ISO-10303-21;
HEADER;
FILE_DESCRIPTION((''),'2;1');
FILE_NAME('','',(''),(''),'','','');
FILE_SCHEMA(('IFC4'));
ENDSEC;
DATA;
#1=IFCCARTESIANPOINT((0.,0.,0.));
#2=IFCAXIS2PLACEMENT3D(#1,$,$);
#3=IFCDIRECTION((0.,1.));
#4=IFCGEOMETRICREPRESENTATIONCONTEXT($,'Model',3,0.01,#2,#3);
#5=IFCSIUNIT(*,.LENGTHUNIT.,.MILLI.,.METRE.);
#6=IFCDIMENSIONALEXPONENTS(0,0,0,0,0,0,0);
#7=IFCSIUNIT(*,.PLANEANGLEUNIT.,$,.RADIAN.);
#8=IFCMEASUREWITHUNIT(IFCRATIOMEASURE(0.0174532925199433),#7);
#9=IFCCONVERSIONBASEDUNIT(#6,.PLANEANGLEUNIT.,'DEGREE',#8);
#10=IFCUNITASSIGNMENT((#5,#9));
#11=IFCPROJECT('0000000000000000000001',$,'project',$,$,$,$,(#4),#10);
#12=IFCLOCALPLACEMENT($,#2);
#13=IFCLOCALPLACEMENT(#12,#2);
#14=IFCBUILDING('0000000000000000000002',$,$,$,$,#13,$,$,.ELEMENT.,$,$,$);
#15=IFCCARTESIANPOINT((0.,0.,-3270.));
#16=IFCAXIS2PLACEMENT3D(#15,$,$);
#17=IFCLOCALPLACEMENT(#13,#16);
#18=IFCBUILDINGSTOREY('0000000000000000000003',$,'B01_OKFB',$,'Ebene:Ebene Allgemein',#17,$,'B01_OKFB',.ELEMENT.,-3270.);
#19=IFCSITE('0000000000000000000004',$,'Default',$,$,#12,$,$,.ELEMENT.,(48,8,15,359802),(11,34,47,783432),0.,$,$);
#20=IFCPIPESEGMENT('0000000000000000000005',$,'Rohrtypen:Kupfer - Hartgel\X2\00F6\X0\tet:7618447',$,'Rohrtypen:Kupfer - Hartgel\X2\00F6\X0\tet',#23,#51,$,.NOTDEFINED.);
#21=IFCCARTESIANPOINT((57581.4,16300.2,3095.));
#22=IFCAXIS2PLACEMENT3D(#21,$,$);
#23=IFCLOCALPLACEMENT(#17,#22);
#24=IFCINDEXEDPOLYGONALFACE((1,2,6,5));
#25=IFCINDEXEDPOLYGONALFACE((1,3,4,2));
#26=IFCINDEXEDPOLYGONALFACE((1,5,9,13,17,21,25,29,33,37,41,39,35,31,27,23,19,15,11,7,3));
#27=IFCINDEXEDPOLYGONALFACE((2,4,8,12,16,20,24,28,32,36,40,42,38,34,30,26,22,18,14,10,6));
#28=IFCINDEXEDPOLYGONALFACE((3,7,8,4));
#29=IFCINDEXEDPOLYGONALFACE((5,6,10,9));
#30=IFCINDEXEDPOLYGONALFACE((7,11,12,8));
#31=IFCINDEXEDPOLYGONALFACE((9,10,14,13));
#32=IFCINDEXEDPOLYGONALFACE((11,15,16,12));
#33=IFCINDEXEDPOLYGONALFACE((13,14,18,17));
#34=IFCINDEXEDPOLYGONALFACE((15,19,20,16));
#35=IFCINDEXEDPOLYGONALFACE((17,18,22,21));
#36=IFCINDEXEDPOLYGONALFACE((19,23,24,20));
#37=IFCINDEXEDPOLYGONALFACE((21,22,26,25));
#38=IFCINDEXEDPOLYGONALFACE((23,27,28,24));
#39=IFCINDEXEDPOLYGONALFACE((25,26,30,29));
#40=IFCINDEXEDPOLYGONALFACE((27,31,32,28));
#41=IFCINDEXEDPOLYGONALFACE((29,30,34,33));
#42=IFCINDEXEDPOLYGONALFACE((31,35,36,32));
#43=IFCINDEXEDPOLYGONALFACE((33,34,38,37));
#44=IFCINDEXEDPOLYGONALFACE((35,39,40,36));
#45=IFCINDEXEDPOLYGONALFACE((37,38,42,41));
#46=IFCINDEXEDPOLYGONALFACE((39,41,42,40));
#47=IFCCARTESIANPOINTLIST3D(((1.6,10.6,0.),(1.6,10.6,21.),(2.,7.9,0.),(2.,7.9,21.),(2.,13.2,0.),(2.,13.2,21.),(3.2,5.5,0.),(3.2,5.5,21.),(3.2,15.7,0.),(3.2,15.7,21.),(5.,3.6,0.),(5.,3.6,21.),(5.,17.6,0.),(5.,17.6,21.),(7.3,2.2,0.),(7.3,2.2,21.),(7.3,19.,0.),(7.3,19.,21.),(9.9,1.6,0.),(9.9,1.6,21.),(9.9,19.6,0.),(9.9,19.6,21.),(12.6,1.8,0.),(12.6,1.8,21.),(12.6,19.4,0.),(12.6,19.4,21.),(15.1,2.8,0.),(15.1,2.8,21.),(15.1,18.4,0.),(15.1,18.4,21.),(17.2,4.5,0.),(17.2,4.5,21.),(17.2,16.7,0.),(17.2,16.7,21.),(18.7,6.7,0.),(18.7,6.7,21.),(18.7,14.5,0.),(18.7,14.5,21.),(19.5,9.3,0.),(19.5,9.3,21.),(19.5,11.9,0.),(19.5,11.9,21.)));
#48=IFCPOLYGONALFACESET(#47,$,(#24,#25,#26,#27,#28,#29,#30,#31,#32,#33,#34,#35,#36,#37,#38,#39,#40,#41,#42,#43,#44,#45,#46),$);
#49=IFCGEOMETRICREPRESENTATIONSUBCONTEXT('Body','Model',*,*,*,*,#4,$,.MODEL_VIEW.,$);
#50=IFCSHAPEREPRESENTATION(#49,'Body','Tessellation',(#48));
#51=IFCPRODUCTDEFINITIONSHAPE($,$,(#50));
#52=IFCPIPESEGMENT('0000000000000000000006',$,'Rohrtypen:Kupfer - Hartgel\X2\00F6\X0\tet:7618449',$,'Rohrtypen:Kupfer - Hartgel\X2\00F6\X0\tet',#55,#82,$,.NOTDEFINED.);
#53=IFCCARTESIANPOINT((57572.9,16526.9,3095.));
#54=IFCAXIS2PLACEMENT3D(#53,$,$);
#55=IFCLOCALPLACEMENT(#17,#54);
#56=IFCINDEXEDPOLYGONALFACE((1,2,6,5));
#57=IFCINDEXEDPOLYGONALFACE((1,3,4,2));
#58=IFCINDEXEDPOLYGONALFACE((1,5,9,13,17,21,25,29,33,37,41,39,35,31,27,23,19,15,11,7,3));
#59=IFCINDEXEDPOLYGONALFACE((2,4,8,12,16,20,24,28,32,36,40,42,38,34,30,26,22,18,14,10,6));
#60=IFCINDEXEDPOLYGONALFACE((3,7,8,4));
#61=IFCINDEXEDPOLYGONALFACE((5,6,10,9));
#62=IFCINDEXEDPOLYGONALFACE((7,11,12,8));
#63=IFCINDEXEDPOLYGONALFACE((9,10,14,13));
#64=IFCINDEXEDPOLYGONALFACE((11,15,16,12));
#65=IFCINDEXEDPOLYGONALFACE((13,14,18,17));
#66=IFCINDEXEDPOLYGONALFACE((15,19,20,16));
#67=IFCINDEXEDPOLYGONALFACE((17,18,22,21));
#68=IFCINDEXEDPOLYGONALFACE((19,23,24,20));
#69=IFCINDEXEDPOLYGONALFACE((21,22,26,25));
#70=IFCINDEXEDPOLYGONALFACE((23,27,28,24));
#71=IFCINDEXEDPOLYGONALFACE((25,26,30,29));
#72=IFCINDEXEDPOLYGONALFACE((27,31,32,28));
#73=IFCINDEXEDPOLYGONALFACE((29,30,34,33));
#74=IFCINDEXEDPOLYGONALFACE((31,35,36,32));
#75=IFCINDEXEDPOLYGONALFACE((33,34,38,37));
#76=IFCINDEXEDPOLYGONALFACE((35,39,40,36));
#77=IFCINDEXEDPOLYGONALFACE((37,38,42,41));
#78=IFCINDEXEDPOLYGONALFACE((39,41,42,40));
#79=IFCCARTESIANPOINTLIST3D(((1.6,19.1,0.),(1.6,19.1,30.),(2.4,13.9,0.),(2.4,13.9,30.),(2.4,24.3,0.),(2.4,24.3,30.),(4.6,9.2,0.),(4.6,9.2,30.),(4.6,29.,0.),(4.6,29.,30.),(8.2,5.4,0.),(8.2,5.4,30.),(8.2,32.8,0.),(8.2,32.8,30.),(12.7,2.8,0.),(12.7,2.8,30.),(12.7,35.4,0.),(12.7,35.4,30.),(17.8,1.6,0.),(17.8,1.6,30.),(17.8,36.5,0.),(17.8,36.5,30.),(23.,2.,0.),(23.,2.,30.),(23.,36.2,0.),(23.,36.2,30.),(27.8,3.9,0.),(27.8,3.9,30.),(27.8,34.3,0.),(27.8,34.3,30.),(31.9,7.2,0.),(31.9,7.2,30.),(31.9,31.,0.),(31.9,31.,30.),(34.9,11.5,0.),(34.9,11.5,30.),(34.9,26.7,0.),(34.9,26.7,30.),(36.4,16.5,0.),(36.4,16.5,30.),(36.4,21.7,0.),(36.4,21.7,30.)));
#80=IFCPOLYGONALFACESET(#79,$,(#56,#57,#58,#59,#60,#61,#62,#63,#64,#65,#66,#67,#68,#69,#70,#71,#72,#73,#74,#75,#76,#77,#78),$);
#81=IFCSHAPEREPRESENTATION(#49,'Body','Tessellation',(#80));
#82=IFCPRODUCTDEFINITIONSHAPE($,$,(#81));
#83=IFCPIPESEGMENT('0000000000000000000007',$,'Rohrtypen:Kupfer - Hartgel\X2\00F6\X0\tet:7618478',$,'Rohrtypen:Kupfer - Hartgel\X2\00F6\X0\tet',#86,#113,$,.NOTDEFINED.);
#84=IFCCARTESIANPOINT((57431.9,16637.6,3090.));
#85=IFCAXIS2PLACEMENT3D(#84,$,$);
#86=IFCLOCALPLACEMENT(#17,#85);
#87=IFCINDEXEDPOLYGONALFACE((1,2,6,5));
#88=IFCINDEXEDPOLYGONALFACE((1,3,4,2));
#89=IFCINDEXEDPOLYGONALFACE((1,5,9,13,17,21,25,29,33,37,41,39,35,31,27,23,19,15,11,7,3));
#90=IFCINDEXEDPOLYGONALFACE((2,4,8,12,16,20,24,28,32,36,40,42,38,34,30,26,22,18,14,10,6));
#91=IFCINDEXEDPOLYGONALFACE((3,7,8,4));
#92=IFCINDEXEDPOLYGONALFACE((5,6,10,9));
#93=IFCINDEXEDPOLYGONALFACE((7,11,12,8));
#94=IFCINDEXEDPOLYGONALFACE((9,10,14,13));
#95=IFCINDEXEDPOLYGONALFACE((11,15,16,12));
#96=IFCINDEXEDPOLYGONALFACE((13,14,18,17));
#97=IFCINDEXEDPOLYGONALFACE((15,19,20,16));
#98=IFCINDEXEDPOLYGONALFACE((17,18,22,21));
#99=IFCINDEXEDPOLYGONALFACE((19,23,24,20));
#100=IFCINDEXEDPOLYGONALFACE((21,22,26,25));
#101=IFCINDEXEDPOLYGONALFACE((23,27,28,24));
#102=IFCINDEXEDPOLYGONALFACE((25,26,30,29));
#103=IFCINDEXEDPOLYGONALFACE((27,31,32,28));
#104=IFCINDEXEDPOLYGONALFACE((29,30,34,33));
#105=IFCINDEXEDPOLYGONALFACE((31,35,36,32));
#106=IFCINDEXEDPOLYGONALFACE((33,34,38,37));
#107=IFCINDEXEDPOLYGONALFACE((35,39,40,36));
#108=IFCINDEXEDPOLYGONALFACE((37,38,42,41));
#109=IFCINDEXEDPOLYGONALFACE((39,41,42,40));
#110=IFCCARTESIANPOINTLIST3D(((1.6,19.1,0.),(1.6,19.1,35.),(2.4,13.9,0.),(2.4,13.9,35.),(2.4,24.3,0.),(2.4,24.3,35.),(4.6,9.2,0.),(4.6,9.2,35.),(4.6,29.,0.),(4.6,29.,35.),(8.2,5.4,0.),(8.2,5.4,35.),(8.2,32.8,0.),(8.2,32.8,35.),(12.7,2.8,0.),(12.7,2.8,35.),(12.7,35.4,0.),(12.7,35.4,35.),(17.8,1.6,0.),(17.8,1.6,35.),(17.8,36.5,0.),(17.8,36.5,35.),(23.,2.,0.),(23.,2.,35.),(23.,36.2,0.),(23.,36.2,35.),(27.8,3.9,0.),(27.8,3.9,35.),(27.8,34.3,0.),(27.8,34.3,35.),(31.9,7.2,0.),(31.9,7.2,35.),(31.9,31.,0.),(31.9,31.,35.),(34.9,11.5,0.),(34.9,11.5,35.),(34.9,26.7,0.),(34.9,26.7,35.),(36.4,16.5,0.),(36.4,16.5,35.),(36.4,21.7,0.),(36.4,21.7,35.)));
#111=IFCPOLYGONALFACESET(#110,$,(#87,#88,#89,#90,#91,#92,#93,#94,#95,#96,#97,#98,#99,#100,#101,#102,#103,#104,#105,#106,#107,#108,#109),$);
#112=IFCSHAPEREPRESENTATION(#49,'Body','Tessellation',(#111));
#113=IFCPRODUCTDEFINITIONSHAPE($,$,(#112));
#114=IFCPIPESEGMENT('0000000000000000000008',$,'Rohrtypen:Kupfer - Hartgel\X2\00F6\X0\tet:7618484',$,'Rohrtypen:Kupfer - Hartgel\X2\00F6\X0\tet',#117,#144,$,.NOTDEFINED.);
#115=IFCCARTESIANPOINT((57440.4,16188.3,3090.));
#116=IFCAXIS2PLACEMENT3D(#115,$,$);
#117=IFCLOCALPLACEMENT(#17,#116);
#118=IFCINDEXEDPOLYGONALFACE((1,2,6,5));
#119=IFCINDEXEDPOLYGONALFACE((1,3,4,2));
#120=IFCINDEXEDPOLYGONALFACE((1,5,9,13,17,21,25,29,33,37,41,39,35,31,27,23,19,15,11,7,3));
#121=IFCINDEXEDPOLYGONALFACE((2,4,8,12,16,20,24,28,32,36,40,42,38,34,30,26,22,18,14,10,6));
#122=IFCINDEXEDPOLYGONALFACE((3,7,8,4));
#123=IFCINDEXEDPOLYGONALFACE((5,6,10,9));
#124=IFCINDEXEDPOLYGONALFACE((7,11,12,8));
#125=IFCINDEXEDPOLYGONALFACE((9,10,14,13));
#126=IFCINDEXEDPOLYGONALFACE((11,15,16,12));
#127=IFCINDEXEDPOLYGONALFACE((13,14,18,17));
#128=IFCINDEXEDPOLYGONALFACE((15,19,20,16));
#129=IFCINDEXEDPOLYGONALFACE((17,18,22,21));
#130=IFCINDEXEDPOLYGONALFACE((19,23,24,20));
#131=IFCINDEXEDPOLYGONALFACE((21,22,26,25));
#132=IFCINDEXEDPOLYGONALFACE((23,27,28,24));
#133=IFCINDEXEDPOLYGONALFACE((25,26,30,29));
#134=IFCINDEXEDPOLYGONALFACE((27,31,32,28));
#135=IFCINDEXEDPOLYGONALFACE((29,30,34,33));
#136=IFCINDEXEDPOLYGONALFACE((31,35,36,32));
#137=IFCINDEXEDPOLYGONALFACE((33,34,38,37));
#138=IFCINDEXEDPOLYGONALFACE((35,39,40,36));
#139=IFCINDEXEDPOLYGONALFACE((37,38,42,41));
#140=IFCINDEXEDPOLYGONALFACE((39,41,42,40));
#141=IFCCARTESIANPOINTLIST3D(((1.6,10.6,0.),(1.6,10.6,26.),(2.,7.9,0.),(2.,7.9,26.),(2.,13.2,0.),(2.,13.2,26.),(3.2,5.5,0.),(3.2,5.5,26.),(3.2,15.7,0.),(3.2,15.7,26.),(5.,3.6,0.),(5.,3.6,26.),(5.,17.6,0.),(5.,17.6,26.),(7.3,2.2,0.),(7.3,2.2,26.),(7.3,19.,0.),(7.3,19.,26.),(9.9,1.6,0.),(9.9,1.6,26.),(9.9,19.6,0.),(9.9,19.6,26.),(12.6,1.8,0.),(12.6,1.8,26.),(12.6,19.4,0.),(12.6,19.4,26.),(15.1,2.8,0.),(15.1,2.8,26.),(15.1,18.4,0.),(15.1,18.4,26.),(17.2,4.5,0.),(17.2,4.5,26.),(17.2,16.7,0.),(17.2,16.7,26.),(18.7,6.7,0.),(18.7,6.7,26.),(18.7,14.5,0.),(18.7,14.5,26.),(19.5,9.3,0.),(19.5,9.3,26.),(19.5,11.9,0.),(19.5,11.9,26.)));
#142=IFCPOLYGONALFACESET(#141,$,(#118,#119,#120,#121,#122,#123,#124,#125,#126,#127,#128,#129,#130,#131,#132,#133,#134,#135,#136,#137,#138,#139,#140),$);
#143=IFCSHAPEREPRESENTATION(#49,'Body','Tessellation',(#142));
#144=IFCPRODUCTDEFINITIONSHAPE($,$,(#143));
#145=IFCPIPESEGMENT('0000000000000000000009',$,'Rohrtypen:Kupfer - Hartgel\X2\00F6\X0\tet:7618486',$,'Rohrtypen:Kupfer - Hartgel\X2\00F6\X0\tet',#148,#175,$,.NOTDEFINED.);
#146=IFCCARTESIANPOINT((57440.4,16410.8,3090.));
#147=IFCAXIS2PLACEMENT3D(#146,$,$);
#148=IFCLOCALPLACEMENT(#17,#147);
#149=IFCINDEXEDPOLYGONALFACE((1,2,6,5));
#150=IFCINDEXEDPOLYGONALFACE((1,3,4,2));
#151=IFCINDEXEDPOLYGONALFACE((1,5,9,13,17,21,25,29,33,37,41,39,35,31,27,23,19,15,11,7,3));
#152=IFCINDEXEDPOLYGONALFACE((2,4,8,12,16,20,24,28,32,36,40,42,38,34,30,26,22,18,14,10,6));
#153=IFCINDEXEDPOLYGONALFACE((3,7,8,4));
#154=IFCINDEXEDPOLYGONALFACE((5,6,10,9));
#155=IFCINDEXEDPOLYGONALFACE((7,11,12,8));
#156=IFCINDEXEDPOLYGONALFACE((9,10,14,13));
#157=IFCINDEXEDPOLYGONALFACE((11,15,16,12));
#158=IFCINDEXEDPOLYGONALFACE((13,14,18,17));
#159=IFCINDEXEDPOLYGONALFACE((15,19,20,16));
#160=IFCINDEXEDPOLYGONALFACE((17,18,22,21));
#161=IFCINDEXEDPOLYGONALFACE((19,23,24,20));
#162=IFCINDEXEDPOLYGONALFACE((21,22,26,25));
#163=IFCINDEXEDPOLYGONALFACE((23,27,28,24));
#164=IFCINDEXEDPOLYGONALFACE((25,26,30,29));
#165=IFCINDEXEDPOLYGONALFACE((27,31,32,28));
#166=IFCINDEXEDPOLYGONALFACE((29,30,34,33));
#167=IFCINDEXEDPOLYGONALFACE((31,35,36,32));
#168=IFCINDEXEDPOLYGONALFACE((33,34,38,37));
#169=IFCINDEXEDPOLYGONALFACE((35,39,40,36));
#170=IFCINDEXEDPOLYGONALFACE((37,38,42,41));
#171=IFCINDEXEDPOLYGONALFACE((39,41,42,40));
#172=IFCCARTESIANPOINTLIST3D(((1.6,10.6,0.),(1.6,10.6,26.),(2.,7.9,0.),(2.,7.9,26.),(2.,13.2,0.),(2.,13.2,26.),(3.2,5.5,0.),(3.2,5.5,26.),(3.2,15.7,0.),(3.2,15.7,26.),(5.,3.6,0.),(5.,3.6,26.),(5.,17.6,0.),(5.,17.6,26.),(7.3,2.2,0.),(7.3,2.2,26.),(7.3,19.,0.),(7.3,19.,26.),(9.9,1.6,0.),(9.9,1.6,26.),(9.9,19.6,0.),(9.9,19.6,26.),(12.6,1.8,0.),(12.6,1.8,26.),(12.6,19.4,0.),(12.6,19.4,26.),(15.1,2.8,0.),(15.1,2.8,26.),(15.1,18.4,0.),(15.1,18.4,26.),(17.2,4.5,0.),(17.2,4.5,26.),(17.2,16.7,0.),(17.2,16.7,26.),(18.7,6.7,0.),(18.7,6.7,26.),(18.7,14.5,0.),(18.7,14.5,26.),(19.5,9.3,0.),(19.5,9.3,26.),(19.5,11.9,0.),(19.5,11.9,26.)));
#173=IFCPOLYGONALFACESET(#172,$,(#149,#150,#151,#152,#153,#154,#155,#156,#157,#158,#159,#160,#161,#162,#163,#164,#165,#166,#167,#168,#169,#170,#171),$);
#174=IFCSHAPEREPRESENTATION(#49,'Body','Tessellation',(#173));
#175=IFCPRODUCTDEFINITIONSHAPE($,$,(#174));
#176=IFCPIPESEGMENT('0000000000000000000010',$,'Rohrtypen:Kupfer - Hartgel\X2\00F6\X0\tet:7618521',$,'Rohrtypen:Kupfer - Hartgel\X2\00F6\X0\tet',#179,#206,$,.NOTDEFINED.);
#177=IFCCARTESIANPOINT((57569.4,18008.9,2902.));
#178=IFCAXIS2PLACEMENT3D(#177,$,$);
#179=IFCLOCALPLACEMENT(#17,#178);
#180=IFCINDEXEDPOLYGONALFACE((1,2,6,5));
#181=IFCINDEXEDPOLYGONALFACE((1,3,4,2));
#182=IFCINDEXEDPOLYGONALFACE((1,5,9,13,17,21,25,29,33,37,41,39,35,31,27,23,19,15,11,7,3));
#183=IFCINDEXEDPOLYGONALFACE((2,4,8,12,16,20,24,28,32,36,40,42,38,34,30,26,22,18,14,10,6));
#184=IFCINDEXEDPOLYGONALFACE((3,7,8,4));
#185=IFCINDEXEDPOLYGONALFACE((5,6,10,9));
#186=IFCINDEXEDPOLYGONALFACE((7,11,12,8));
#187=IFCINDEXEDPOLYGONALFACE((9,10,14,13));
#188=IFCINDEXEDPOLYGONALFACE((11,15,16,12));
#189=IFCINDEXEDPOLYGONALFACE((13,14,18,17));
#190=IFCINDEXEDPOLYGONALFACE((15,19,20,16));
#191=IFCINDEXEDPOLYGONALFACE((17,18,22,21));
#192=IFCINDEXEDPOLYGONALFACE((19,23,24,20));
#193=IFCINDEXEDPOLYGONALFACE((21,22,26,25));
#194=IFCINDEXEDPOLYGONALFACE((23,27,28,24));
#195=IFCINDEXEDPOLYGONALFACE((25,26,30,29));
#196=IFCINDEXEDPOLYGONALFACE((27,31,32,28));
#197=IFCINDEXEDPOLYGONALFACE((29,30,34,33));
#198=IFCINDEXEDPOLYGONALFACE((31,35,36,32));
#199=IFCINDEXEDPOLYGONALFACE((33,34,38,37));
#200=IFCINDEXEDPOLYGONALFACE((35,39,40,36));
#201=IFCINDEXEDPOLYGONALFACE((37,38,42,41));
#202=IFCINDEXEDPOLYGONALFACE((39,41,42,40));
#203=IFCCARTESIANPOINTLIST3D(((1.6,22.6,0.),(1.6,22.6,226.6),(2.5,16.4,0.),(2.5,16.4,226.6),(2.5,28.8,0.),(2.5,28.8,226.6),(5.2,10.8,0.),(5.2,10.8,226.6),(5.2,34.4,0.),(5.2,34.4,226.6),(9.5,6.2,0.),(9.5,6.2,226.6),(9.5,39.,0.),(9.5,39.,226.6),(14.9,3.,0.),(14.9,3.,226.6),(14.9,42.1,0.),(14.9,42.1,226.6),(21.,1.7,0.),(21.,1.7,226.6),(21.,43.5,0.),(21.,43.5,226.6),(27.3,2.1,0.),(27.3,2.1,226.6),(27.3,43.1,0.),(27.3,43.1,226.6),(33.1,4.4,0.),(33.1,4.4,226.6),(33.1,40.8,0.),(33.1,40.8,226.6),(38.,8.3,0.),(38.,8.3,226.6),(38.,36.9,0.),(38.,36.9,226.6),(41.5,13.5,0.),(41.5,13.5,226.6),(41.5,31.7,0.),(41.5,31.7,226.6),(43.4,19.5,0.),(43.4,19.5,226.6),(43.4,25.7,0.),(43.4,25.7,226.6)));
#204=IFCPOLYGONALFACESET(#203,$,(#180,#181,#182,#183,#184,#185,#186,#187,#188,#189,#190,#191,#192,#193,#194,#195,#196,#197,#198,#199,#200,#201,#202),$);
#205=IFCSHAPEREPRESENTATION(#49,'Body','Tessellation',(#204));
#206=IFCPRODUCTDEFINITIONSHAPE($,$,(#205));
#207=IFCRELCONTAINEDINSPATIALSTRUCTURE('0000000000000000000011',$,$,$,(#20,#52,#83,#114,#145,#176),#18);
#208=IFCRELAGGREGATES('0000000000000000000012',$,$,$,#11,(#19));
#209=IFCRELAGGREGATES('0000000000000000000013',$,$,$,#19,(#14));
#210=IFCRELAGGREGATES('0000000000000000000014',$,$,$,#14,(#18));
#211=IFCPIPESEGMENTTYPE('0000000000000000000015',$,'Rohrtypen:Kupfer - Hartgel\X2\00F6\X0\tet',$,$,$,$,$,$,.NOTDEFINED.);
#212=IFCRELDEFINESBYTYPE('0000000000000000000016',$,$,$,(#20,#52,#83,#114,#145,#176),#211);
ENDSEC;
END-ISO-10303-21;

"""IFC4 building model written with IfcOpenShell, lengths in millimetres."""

from ifc_helpers import new_model, entity, si_unit, converted_unit, direction, frame, frame_2d, origin, origin_2d_with_axis, place, context, subcontext, project, spatial, circle, extrude, type_object, element, save


model = new_model("IFC4")

# Units and contexts
model_context = context("Model", 3, precision=0.01, world=origin(), true_north=direction((0.0, 1.0)))
body_context = subcontext(model_context, "Body", "Model", "MODEL_VIEW")
ifc_project = project(units=[si_unit("LENGTHUNIT", "METRE", prefix="MILLI"), converted_unit("PLANEANGLEUNIT", "DEGREE", entity("IfcRatioMeasure", 0.0174532925199433), si_unit("PLANEANGLEUNIT", "RADIAN"), dimensions=[0, 0, 0, 0, 0, 0, 0])], contexts=[model_context])

# Site, building, storey
site_placement = place(None, origin())
site = spatial("IfcSite", under=ifc_project, at=site_placement, Name="Default", CompositionType="ELEMENT", RefLatitude=(48, 8, 15, 359802), RefLongitude=(11, 34, 47, 783432), RefElevation=0.0)
building_placement = place(site_placement, origin())
building = spatial("IfcBuilding", under=site, at=building_placement, CompositionType="ELEMENT")
storey_placement = place(building_placement, frame((0.0, 0.0, -3270.0)))
storey = spatial("IfcBuildingStorey", under=building, at=storey_placement, Name="B01_OKFB", ObjectType="Ebene:Ebene Allgemein", LongName="B01_OKFB", CompositionType="ELEMENT", Elevation=-3270.0)

# Pipe segments
pipe_segment_type = type_object("IfcPipeSegmentType", Name="Rohrtypen:Kupfer - Hartgelötet", PredefinedType="NOTDEFINED")
pipe_segment_1_placement = place(storey_placement, frame((57581.4, 16300.2, 3095.0)))
element("IfcPipeSegment", 1, at=pipe_segment_1_placement, inside=storey, type_object=pipe_segment_type, Name="Rohrtypen:Kupfer - Hartgelötet:7618447", ObjectType="Rohrtypen:Kupfer - Hartgelötet", PredefinedType="NOTDEFINED", context=body_context, shape_type="SweptSolid", body=[
    extrude(circle(Radius=9.0, at=frame_2d((0.0, 0.0), x_axis=(1.0, 0.0))), frame((10.6, 10.6, 0.0), z_axis=(0.0, 0.0, 1.0), x_axis=(-1.0, 0.0, 0.0)), (0.0, 0.0, 1.0), 21.0),
])
pipe_segment_2_placement = place(storey_placement, frame((57572.9, 16526.9, 3095.0)))
element("IfcPipeSegment", 2, at=pipe_segment_2_placement, inside=storey, type_object=pipe_segment_type, Name="Rohrtypen:Kupfer - Hartgelötet:7618449", ObjectType="Rohrtypen:Kupfer - Hartgelötet", PredefinedType="NOTDEFINED", context=body_context, shape_type="SweptSolid", body=[
    extrude(circle(Radius=17.5, at=origin_2d_with_axis()), frame((19.1, 19.1, 0.0), z_axis=(0.0, 0.0, 1.0), x_axis=(-1.0, 0.0, 0.0)), (0.0, 0.0, 1.0), 30.0),
])
pipe_segment_3_placement = place(storey_placement, frame((57431.9, 16637.6, 3090.0)))
element("IfcPipeSegment", 3, at=pipe_segment_3_placement, inside=storey, type_object=pipe_segment_type, Name="Rohrtypen:Kupfer - Hartgelötet:7618478", ObjectType="Rohrtypen:Kupfer - Hartgelötet", PredefinedType="NOTDEFINED", context=body_context, shape_type="SweptSolid", body=[
    extrude(circle(Radius=17.5, at=origin_2d_with_axis()), frame((19.1, 19.1, 0.0), z_axis=(0.0, 0.0, 1.0), x_axis=(-1.0, 0.0, 0.0)), (0.0, 0.0, 1.0), 35.0),
])
pipe_segment_4_placement = place(storey_placement, frame((57440.4, 16188.3, 3090.0)))
element("IfcPipeSegment", 4, at=pipe_segment_4_placement, inside=storey, type_object=pipe_segment_type, Name="Rohrtypen:Kupfer - Hartgelötet:7618484", ObjectType="Rohrtypen:Kupfer - Hartgelötet", PredefinedType="NOTDEFINED", context=body_context, shape_type="SweptSolid", body=[
    extrude(circle(Radius=9.0, at=frame_2d((0.0, 0.0), x_axis=(1.0, 0.0))), frame((10.6, 10.6, 0.0), z_axis=(0.0, 0.0, 1.0), x_axis=(-1.0, 0.0, 0.0)), (0.0, 0.0, 1.0), 26.0),
])
pipe_segment_5_placement = place(storey_placement, frame((57440.4, 16410.8, 3090.0)))
element("IfcPipeSegment", 5, at=pipe_segment_5_placement, inside=storey, type_object=pipe_segment_type, Name="Rohrtypen:Kupfer - Hartgelötet:7618486", ObjectType="Rohrtypen:Kupfer - Hartgelötet", PredefinedType="NOTDEFINED", context=body_context, shape_type="SweptSolid", body=[
    extrude(circle(Radius=9.0, at=origin_2d_with_axis()), frame((10.6, 10.6, 0.0), z_axis=(0.0, 0.0, 1.0), x_axis=(-1.0, 0.0, 0.0)), (0.0, 0.0, 1.0), 26.0),
])
pipe_segment_6_placement = place(storey_placement, frame((57569.4, 18008.9, 2902.0)))
element("IfcPipeSegment", 6, at=pipe_segment_6_placement, inside=storey, type_object=pipe_segment_type, Name="Rohrtypen:Kupfer - Hartgelötet:7618521", ObjectType="Rohrtypen:Kupfer - Hartgelötet", PredefinedType="NOTDEFINED", context=body_context, shape_type="SweptSolid", body=[
    extrude(circle(Radius=21.0, at=origin_2d_with_axis()), frame((22.6, 22.6, 0.0), z_axis=(0.0, 0.0, 1.0), x_axis=(-1.0, 0.0, 0.0)), (0.0, 0.0, 1.0), 226.6),
])

save(model, "model.ifc")
